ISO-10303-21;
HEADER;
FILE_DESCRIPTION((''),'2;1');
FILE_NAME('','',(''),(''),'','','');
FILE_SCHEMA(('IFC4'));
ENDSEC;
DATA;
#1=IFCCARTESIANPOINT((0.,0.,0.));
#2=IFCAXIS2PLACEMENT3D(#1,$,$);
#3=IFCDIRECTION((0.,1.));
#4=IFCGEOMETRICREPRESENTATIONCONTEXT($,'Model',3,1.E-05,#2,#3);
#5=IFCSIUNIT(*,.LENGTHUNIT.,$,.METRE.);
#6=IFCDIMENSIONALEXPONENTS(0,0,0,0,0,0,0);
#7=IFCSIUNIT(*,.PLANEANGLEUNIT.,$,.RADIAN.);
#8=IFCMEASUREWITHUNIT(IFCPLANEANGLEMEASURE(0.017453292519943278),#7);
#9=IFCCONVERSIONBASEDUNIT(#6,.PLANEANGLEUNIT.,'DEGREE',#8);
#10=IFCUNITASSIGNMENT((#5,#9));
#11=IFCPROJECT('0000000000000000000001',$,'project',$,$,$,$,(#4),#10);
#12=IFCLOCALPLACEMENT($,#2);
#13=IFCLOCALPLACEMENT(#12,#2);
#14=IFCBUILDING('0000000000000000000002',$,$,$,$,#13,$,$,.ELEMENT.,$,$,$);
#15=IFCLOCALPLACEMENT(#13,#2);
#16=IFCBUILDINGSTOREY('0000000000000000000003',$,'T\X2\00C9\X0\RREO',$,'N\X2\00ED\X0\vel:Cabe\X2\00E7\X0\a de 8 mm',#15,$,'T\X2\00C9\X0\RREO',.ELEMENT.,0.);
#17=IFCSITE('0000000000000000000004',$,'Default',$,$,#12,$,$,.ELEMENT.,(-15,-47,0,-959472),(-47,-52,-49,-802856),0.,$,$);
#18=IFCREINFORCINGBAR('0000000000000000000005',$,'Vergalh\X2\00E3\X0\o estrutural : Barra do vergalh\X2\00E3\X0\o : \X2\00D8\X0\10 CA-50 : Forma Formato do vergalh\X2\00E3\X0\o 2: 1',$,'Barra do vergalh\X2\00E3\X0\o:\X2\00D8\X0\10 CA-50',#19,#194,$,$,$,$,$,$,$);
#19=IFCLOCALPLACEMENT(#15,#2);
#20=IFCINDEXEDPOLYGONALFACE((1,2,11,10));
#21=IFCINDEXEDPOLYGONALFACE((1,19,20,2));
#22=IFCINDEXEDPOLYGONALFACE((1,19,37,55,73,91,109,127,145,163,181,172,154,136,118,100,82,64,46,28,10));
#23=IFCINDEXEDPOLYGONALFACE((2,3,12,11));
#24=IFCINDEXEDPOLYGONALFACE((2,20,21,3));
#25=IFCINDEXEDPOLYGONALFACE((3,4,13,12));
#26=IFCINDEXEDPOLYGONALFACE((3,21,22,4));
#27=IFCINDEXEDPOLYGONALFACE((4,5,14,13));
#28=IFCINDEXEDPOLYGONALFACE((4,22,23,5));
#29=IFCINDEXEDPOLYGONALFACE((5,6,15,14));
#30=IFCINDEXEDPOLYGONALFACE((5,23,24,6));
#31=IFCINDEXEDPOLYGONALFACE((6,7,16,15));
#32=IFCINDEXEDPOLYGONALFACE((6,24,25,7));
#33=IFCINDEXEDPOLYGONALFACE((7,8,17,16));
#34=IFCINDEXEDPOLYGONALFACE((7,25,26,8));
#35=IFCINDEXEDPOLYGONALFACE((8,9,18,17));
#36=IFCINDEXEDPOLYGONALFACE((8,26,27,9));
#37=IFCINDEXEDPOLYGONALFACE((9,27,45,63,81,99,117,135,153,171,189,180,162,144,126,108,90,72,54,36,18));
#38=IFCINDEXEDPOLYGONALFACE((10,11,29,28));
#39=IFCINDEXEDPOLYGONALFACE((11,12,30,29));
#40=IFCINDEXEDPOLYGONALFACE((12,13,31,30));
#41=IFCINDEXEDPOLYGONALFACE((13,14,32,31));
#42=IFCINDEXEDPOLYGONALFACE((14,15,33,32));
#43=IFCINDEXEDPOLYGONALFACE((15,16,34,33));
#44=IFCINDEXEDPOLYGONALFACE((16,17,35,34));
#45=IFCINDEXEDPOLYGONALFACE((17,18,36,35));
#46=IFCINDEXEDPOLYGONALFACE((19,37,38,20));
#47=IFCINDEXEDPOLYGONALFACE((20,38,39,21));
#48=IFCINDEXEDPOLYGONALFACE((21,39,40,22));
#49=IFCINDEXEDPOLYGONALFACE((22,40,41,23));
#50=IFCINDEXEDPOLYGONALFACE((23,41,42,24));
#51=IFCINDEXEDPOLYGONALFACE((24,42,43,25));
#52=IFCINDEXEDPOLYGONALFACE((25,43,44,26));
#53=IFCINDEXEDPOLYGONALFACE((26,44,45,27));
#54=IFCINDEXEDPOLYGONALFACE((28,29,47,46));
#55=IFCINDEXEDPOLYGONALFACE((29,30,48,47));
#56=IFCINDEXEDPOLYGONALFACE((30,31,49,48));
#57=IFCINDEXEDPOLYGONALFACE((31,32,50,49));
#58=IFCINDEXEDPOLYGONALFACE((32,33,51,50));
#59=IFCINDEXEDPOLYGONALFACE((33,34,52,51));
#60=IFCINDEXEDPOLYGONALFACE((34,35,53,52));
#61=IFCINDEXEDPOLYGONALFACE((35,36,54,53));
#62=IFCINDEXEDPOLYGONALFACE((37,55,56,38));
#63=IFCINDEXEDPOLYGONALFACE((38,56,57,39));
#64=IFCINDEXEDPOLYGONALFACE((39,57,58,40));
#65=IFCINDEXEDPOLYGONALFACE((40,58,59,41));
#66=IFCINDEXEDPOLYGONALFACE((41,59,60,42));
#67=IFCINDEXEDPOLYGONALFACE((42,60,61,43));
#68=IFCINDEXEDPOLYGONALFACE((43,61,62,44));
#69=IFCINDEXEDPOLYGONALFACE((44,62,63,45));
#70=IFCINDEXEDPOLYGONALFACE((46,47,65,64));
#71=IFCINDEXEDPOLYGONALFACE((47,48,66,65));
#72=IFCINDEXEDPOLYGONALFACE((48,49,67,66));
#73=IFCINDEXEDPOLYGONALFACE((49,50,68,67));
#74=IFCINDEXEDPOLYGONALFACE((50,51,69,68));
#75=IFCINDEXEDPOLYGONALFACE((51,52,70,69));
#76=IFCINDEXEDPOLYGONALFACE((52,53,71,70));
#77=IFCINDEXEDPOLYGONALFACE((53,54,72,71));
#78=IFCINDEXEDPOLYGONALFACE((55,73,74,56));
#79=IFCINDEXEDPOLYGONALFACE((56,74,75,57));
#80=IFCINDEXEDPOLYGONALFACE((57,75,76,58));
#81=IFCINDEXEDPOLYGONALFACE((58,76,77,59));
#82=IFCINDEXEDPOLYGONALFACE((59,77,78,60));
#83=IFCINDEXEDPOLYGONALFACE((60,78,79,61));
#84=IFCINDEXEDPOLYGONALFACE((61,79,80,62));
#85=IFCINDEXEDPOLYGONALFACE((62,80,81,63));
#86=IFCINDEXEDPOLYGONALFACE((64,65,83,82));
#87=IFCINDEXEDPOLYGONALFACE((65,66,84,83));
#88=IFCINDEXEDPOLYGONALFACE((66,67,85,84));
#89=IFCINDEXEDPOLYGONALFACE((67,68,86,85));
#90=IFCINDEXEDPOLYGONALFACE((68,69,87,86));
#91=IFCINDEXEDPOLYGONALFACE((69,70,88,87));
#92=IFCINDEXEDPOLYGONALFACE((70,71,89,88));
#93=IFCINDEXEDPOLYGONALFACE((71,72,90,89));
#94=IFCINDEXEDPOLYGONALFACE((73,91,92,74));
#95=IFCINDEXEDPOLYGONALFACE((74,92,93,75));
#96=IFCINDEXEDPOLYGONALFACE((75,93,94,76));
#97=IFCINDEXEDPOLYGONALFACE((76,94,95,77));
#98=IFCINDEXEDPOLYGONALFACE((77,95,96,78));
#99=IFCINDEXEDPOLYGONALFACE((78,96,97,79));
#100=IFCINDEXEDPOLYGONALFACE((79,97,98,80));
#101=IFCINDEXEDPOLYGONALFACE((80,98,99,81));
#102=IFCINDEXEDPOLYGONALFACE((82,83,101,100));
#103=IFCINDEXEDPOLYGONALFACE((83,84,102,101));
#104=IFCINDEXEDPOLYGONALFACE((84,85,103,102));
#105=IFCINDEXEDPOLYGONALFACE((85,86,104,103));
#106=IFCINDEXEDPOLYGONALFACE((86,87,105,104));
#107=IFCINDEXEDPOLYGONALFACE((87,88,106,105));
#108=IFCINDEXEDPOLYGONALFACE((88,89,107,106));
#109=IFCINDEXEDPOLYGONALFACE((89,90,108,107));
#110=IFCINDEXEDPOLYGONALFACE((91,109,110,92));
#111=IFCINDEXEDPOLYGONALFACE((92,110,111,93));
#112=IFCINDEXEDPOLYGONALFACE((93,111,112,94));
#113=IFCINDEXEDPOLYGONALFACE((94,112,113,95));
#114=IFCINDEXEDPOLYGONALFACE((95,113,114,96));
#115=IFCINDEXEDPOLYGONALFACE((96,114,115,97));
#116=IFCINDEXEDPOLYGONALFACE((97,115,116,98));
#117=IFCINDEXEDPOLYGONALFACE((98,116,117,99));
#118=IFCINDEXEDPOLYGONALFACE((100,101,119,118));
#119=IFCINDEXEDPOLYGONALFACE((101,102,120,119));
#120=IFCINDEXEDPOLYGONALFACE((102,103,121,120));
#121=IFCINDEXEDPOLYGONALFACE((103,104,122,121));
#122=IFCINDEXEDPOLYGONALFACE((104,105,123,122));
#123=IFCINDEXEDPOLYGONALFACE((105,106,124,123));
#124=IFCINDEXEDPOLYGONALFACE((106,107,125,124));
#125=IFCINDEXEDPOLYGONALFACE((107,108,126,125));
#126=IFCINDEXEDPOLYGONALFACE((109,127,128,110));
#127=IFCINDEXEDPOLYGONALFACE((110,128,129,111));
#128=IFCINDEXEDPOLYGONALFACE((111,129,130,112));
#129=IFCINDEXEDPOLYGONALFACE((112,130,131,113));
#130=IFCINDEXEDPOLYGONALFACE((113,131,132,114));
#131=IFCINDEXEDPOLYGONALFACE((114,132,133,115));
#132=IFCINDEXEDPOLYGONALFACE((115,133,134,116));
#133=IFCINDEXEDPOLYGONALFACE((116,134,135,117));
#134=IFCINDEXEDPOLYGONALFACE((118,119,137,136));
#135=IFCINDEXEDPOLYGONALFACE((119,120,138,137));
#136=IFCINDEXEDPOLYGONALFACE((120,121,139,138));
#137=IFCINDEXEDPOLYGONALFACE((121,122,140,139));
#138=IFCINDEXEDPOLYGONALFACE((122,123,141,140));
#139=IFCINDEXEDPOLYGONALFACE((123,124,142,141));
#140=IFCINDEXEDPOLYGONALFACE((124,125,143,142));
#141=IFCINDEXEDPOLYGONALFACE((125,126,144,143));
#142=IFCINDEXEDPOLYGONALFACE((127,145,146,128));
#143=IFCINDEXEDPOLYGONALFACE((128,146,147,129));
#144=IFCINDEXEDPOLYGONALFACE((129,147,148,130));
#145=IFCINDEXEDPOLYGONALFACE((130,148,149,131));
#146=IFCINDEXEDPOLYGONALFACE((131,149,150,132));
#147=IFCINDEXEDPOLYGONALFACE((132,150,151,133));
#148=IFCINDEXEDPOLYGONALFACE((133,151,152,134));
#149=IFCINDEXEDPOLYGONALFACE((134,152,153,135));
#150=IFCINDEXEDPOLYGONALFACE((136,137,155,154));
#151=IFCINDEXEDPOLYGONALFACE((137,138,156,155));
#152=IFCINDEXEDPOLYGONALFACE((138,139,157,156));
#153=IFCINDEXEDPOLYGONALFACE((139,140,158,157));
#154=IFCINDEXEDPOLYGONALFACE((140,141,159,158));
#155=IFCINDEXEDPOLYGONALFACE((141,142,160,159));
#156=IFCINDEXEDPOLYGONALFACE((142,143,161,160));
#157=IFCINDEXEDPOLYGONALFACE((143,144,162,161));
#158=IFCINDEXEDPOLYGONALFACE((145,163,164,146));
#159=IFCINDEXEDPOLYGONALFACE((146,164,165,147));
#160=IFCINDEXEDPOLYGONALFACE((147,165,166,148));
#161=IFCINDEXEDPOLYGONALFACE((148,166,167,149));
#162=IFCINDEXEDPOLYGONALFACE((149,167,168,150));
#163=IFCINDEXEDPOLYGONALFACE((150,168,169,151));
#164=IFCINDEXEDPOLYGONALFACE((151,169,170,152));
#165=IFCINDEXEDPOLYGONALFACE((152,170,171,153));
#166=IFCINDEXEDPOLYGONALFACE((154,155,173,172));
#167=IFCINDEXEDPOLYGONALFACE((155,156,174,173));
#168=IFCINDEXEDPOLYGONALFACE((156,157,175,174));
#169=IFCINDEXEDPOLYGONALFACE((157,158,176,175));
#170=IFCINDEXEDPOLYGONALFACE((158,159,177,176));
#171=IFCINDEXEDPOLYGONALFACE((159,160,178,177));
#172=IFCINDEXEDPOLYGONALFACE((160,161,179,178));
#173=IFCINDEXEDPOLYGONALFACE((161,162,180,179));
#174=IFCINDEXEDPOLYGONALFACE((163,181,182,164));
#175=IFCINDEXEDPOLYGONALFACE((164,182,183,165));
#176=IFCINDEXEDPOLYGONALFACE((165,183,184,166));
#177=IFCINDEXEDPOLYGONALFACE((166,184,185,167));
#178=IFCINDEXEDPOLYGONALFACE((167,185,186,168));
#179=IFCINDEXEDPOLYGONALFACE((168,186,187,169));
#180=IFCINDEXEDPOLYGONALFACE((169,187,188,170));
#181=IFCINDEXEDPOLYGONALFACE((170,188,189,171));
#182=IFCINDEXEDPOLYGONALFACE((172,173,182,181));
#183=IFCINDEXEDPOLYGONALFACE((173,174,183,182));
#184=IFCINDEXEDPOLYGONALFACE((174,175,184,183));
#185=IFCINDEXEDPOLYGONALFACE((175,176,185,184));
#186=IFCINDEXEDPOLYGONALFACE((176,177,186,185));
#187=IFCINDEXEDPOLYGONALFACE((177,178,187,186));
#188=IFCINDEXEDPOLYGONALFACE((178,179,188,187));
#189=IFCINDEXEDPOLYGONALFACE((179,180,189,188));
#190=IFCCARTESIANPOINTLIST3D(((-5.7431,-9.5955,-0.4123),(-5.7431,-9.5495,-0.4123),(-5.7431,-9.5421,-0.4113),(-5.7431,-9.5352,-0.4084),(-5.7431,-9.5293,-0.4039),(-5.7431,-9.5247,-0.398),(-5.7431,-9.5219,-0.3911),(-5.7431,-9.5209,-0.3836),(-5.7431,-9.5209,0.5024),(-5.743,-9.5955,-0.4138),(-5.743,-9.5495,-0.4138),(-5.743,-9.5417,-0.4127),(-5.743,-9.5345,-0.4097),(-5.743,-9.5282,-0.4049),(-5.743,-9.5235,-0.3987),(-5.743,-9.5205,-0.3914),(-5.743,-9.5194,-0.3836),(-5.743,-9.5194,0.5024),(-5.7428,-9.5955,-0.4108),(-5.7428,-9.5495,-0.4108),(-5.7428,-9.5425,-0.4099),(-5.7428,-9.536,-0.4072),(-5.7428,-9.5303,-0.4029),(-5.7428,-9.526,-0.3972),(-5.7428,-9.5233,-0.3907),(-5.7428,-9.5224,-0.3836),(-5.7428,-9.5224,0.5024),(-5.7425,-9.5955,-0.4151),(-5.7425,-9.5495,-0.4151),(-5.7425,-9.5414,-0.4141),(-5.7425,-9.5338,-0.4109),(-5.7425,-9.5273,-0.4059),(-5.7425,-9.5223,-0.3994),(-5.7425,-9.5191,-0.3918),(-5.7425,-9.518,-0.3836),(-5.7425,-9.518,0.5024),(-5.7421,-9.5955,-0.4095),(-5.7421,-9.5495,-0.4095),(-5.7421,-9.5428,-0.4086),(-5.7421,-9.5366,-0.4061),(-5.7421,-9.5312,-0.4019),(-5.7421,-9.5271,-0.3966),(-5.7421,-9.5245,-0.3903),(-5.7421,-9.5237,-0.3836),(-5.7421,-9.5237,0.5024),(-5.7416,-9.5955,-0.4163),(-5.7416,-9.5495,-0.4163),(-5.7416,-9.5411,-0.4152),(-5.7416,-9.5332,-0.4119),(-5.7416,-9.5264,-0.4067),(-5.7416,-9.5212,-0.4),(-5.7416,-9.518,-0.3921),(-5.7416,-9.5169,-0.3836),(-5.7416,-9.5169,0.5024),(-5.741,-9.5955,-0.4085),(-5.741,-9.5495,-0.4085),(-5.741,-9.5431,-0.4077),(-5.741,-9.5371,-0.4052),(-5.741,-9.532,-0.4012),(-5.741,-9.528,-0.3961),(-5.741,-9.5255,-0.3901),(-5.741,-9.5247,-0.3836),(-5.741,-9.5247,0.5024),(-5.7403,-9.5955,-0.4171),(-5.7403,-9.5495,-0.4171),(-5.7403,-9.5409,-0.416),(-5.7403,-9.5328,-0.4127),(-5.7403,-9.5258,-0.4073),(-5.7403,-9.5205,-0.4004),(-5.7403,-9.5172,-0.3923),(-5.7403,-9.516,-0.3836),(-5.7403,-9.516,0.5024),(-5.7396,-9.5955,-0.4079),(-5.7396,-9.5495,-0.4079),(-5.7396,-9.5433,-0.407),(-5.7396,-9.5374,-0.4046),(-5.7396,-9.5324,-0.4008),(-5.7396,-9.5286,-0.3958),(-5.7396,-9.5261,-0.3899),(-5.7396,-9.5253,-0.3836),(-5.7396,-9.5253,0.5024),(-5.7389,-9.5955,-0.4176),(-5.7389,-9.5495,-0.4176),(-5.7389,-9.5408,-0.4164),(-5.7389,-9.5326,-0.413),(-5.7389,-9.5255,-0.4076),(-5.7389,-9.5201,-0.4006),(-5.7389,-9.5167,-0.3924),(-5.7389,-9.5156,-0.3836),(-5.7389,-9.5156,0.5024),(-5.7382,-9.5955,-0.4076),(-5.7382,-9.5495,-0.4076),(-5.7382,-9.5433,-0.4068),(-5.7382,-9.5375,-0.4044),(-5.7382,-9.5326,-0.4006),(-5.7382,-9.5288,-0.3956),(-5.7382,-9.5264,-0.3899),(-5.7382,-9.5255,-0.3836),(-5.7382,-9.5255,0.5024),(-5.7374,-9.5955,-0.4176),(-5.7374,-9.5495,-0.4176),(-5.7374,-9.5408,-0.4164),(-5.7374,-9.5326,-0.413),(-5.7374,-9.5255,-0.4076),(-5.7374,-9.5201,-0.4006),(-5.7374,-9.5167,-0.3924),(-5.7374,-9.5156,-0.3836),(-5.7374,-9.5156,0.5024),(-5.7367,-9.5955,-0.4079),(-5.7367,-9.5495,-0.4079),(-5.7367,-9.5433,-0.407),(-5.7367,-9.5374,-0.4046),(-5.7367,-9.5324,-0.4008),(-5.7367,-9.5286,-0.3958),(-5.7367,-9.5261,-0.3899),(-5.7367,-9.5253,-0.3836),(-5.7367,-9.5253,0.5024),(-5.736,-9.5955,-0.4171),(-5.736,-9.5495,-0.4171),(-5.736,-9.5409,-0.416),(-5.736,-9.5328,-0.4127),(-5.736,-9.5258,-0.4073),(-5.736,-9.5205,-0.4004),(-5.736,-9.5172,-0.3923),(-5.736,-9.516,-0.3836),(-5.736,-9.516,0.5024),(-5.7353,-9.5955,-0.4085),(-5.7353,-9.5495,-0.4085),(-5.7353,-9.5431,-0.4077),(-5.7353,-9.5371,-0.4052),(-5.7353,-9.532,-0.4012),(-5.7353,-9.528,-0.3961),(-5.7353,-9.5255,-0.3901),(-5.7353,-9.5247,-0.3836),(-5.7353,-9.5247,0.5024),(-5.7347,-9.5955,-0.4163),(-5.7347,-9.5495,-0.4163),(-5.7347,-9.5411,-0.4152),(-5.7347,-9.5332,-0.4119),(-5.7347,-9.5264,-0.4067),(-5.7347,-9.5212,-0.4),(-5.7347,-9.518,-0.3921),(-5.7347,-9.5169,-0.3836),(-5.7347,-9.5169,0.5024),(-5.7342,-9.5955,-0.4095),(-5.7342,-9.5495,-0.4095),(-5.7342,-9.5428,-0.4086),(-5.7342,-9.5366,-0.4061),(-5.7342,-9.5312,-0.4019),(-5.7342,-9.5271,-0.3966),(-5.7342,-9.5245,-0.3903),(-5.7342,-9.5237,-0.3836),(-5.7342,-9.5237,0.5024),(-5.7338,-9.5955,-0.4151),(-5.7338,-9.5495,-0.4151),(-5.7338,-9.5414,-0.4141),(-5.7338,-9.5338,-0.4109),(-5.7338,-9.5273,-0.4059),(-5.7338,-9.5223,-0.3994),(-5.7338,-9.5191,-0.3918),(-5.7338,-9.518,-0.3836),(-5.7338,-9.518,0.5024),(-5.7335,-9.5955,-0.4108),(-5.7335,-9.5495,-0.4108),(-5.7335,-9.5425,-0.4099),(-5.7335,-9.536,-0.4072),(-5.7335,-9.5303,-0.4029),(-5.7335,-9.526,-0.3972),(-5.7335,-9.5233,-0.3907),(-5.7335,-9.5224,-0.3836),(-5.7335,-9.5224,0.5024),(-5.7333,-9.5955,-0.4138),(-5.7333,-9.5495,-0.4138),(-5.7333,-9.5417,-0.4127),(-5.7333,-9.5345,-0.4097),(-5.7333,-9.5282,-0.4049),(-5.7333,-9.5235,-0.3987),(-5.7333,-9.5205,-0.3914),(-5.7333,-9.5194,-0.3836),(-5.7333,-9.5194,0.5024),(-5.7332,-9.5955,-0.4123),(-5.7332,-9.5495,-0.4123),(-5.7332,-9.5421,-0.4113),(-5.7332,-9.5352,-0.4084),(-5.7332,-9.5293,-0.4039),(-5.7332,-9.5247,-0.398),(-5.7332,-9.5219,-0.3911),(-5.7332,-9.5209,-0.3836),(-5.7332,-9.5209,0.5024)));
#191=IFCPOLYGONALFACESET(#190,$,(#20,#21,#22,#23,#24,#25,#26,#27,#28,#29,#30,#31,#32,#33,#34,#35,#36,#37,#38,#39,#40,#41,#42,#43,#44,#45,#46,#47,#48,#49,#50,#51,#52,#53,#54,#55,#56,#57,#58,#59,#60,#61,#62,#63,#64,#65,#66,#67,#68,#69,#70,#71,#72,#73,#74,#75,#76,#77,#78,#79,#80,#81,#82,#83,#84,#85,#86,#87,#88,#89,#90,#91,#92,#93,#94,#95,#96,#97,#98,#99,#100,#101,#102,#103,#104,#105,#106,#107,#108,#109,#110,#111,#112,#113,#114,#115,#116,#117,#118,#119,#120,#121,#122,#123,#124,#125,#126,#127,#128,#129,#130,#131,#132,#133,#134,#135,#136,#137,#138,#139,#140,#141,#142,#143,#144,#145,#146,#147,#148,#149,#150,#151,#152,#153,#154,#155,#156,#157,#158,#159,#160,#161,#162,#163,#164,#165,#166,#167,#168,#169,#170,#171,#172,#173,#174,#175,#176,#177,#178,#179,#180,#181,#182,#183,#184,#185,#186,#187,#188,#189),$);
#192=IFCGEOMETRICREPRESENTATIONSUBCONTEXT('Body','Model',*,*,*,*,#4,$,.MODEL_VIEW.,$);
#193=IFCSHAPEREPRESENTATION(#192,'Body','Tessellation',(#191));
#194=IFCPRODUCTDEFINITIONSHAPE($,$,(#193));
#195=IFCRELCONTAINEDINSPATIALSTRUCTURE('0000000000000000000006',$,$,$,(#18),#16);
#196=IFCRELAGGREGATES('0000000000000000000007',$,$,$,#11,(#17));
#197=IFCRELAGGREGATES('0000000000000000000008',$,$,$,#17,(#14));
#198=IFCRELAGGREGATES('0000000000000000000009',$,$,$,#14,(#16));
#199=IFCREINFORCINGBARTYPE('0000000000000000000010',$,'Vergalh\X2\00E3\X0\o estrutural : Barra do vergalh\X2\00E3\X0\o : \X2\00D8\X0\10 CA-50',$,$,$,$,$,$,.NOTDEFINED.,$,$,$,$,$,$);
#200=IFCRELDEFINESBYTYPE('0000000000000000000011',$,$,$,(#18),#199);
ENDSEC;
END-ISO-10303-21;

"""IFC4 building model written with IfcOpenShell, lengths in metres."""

from ifc_helpers import new_model, entity, si_unit, converted_unit, direction, origin, place, context, subcontext, project, spatial, type_object, element, save


model = new_model("IFC4")

# Units and contexts
model_context = context("Model", 3, precision=1e-05, world=origin(), true_north=direction((0.0, 1.0)))
body_context = subcontext(model_context, "Body", "Model", "MODEL_VIEW")
ifc_project = project(units=[si_unit("LENGTHUNIT", "METRE"), converted_unit("PLANEANGLEUNIT", "DEGREE", entity("IfcPlaneAngleMeasure", 0.017453292519943278), si_unit("PLANEANGLEUNIT", "RADIAN"), dimensions=[0, 0, 0, 0, 0, 0, 0])], contexts=[model_context])

# Site, building, storey
site_placement = place(None, origin())
site = spatial("IfcSite", under=ifc_project, at=site_placement, Name="Default", CompositionType="ELEMENT", RefLatitude=(-15, -47, 0, -959472), RefLongitude=(-47, -52, -49, -802856), RefElevation=0.0)
building_placement = place(site_placement, origin())
building = spatial("IfcBuilding", under=site, at=building_placement, CompositionType="ELEMENT")
storey_placement = place(building_placement, origin())
storey = spatial("IfcBuildingStorey", under=building, at=storey_placement, Name="TÉRREO", ObjectType="Nível:Cabeça de 8 mm", LongName="TÉRREO", CompositionType="ELEMENT", Elevation=0.0)

# Reinforcing bar
reinforcing_bar_type_1 = type_object("IfcReinforcingBarType", Name="Vergalhão estrutural : Barra do vergalhão : Ø10 CA-50", PredefinedType="NOTDEFINED")
reinforcing_bar_1_placement = place(storey_placement, origin())
element("IfcReinforcingBar", 1, at=reinforcing_bar_1_placement, inside=storey, type_object=reinforcing_bar_type_1, Name="Vergalhão estrutural : Barra do vergalhão : Ø10 CA-50 : Forma Formato do vergalhão 2: 1", ObjectType="Barra do vergalhão:Ø10 CA-50", context=body_context, shape_type="AdvancedSweptSolid", body=[
    entity("IfcSweptDiskSolid", entity("IfcIndexedPolyCurve", entity("IfcCartesianPointList3D", [[-5.7382, -9.5955, -0.4126], [-5.7382, -9.5495, -0.4126], [-5.7382, -9.529, -0.4042], [-5.7382, -9.5205, -0.3836], [-5.7382, -9.5205, 0.5024]]), [entity("IfcLineIndex", [1, 2]), entity("IfcArcIndex", [2, 3, 4]), entity("IfcLineIndex", [4, 5])], False), 0.005, None, 0.0, 92.0),
])

save(model, "model.ifc")
